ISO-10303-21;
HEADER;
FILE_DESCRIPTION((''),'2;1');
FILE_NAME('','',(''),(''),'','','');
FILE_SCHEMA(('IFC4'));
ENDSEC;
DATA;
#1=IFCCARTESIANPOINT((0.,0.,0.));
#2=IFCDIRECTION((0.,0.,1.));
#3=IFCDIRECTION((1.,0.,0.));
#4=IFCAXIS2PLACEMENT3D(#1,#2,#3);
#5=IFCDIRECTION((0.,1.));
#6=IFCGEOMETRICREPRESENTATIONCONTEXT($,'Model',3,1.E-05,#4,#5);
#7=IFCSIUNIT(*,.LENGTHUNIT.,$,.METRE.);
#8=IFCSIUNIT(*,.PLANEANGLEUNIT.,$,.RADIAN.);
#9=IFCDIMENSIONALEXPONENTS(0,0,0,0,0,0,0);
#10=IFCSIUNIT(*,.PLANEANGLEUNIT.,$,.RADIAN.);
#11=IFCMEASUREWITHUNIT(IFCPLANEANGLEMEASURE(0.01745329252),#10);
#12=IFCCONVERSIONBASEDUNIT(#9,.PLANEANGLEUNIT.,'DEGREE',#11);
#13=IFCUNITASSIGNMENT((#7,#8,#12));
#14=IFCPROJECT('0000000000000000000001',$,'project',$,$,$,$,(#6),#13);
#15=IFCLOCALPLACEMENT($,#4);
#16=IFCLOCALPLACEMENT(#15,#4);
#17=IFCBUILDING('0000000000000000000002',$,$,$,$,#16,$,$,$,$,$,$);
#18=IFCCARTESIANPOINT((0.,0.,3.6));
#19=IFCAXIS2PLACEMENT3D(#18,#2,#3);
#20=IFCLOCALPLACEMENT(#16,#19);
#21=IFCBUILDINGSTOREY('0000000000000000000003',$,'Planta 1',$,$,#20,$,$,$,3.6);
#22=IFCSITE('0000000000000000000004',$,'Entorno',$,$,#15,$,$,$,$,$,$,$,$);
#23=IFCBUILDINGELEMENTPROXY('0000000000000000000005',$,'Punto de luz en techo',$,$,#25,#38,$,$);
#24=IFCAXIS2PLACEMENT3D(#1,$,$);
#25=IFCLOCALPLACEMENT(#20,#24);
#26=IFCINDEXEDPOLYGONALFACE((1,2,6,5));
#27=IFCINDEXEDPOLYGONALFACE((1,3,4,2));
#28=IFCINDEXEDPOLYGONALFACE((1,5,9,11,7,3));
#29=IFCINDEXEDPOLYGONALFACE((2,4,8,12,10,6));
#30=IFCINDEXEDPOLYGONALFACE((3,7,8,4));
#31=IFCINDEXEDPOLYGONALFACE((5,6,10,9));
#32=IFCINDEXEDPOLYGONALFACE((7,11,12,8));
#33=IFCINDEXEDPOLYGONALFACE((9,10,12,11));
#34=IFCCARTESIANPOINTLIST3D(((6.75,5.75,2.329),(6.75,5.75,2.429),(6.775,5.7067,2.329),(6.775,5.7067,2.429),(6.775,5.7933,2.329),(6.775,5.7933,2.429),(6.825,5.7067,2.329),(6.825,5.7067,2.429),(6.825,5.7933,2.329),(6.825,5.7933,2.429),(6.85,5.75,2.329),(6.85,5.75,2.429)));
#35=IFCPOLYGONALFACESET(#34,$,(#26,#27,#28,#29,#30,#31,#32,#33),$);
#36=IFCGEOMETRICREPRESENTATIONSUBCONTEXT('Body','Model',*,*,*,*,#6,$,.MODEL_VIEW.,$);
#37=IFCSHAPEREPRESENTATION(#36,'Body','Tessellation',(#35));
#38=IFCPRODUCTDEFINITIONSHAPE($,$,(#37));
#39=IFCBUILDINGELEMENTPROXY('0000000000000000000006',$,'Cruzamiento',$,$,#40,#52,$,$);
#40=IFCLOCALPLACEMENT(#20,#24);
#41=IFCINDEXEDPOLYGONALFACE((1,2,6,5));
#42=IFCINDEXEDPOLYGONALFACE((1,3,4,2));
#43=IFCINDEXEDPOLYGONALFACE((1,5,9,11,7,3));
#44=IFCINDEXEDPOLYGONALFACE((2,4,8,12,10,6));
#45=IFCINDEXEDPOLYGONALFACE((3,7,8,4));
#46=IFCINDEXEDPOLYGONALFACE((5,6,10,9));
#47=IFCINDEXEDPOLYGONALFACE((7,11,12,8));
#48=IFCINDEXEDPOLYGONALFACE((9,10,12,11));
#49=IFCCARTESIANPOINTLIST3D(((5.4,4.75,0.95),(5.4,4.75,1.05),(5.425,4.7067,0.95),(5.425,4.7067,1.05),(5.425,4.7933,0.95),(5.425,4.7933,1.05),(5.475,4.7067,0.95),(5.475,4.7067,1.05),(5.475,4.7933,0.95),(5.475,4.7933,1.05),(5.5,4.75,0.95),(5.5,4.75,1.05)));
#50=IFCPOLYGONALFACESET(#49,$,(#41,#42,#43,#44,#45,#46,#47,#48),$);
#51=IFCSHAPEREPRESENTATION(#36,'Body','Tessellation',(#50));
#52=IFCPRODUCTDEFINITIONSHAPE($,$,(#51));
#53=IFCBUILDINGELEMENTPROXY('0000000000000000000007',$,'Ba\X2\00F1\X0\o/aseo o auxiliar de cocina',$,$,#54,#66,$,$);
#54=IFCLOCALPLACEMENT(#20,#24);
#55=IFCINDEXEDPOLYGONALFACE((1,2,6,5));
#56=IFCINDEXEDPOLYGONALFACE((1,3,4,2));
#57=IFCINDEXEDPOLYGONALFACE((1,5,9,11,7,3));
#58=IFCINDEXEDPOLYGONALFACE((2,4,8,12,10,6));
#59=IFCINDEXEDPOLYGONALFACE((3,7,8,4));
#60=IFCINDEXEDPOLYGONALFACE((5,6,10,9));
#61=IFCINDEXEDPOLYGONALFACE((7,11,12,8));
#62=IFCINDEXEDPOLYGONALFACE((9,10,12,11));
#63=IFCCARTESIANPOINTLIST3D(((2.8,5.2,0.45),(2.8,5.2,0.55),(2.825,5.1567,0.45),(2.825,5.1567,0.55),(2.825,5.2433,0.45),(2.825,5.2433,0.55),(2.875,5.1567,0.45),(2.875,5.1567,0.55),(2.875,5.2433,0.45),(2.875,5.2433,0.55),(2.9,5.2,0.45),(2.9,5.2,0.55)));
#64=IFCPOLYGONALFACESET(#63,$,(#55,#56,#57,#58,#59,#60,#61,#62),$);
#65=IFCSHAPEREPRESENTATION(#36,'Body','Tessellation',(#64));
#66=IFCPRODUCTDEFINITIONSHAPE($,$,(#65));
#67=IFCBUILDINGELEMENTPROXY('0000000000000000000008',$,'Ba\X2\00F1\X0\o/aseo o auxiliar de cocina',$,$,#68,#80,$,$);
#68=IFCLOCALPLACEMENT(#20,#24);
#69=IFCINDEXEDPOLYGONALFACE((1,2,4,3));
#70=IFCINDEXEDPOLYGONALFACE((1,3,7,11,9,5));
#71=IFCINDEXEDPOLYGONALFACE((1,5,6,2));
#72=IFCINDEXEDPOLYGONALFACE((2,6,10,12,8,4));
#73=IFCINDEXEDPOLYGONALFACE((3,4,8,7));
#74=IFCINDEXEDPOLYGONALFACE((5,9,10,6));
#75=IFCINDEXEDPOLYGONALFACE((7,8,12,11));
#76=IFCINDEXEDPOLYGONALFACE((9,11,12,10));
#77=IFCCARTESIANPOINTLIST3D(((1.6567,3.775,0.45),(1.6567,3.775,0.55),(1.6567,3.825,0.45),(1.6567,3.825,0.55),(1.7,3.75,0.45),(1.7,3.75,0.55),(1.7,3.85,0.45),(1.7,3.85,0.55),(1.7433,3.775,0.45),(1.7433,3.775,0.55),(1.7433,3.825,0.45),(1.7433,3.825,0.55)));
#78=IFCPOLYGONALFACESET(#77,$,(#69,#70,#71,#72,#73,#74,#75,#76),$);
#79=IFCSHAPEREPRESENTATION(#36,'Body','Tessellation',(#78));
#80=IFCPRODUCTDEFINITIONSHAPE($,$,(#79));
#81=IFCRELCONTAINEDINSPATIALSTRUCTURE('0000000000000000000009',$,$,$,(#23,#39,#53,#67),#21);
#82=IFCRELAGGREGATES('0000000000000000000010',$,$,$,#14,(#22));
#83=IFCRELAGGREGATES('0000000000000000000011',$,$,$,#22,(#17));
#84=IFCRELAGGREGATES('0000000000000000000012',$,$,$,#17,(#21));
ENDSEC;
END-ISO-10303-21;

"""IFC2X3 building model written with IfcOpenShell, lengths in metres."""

from ifc_helpers import new_model, entity, si_unit, converted_unit, direction, frame, origin_with_axes, place, context, subcontext, project, spatial, polyline, outline, extrude, source, transform, mapped, element, save


model = new_model("IFC2X3")

# Units and contexts
model_context = context("Model", 3, precision=1e-05, world=origin_with_axes(), true_north=direction((0.0, 1.0)))
body_context = subcontext(model_context, "Body", "Model", "MODEL_VIEW")
ifc_project = project(units=[si_unit("LENGTHUNIT", "METRE"), si_unit("PLANEANGLEUNIT", "RADIAN"), converted_unit("PLANEANGLEUNIT", "DEGREE", entity("IfcPlaneAngleMeasure", 0.01745329252), si_unit("PLANEANGLEUNIT", "RADIAN"), dimensions=[0, 0, 0, 0, 0, 0, 0])], contexts=[model_context])

# Site, building, storey
site_placement = place(None, origin_with_axes())
site = spatial("IfcSite", under=ifc_project, at=site_placement, Name="Entorno")
building_placement = place(site_placement, origin_with_axes())
building = spatial("IfcBuilding", under=site, at=building_placement)
storey_placement = place(building_placement, frame((0.0, 0.0, 3.6), z_axis=(0.0, 0.0, 1.0), x_axis=(1.0, 0.0, 0.0)))
storey = spatial("IfcBuildingStorey", under=building, at=storey_placement, Name="Planta 1", Elevation=3.6)

# Building element proxies
shared_shape_1 = source(origin_with_axes(), body_context, "Body", "SolidModel", [
    extrude(outline(polyline([(0.05, 0.0), (0.025, 0.0433), (-0.025, 0.0433), (-0.05, 0.0), (-0.025, -0.0433), (0.025, -0.0433), (0.05, 0.0)])), frame((0.0, 0.0, -0.05), z_axis=(0.0, 0.0, 1.0), x_axis=(1.0, 0.0, 0.0)), (0.0, 0.0, 1.0), 0.1),
])
proxy_1_placement = place(storey_placement, frame((0.0, 0.0, -3.6), z_axis=(0.0, 0.0, 1.0), x_axis=(1.0, 0.0, 0.0)))
element("IfcBuildingElementProxy", 1, at=proxy_1_placement, inside=storey, Name="Punto de luz en techo", context=body_context, shape_type="Brep", body=[
    mapped(shared_shape_1, transform((6.8, 5.75, 5.979), x_axis=(1.0, 0.0, 0.0), y_axis=(0.0, 1.0, 0.0), z_axis=(0.0, 0.0, 1.0))),
])
shared_shape_2 = source(origin_with_axes(), body_context, "Body", "SolidModel", [
    extrude(outline(polyline([(0.05, 0.0), (0.025, 0.0433), (-0.025, 0.0433), (-0.05, 0.0), (-0.025, -0.0433), (0.025, -0.0433), (0.05, 0.0)])), frame((0.0, 0.0, -0.05), z_axis=(0.0, 0.0, 1.0), x_axis=(1.0, 0.0, 0.0)), (0.0, 0.0, 1.0), 0.1),
])
proxy_2_placement = place(storey_placement, frame((0.0, 0.0, -3.6), z_axis=(0.0, 0.0, 1.0), x_axis=(1.0, 0.0, 0.0)))
element("IfcBuildingElementProxy", 2, at=proxy_2_placement, inside=storey, Name="Cruzamiento", context=body_context, shape_type="Brep", body=[
    mapped(shared_shape_2, transform((5.45, 4.75, 4.6), x_axis=(1.0, 0.0, 0.0), y_axis=(0.0, 1.0, 0.0), z_axis=(0.0, 0.0, 1.0))),
])
shared_shape_3 = source(origin_with_axes(), body_context, "Body", "SolidModel", [
    extrude(outline(polyline([(0.05, 0.0), (0.025, 0.0433), (-0.025, 0.0433), (-0.05, 0.0), (-0.025, -0.0433), (0.025, -0.0433), (0.05, 0.0)])), frame((0.0, 0.0, -0.05), z_axis=(0.0, 0.0, 1.0), x_axis=(1.0, 0.0, 0.0)), (0.0, 0.0, 1.0), 0.1),
])
proxy_3_placement = place(storey_placement, frame((0.0, 0.0, -3.6), z_axis=(0.0, 0.0, 1.0), x_axis=(1.0, 0.0, 0.0)))
element("IfcBuildingElementProxy", 3, at=proxy_3_placement, inside=storey, Name="Baño/aseo o auxiliar de cocina", context=body_context, shape_type="Brep", body=[
    mapped(shared_shape_3, transform((2.85, 5.2, 4.1), x_axis=(-1.0, 0.0, 0.0), y_axis=(0.0, -1.0, 0.0), z_axis=(0.0, 0.0, 1.0))),
])
proxy_4_placement = place(storey_placement, frame((0.0, 0.0, -3.6), z_axis=(0.0, 0.0, 1.0), x_axis=(1.0, 0.0, 0.0)))
element("IfcBuildingElementProxy", 4, at=proxy_4_placement, inside=storey, Name="Baño/aseo o auxiliar de cocina", context=body_context, shape_type="Brep", body=[
    mapped(shared_shape_3, transform((1.7, 3.8, 4.1), x_axis=(0.0, 1.0, 0.0), y_axis=(-1.0, 0.0, 0.0), z_axis=(0.0, 0.0, 1.0))),
])

save(model, "model.ifc")
